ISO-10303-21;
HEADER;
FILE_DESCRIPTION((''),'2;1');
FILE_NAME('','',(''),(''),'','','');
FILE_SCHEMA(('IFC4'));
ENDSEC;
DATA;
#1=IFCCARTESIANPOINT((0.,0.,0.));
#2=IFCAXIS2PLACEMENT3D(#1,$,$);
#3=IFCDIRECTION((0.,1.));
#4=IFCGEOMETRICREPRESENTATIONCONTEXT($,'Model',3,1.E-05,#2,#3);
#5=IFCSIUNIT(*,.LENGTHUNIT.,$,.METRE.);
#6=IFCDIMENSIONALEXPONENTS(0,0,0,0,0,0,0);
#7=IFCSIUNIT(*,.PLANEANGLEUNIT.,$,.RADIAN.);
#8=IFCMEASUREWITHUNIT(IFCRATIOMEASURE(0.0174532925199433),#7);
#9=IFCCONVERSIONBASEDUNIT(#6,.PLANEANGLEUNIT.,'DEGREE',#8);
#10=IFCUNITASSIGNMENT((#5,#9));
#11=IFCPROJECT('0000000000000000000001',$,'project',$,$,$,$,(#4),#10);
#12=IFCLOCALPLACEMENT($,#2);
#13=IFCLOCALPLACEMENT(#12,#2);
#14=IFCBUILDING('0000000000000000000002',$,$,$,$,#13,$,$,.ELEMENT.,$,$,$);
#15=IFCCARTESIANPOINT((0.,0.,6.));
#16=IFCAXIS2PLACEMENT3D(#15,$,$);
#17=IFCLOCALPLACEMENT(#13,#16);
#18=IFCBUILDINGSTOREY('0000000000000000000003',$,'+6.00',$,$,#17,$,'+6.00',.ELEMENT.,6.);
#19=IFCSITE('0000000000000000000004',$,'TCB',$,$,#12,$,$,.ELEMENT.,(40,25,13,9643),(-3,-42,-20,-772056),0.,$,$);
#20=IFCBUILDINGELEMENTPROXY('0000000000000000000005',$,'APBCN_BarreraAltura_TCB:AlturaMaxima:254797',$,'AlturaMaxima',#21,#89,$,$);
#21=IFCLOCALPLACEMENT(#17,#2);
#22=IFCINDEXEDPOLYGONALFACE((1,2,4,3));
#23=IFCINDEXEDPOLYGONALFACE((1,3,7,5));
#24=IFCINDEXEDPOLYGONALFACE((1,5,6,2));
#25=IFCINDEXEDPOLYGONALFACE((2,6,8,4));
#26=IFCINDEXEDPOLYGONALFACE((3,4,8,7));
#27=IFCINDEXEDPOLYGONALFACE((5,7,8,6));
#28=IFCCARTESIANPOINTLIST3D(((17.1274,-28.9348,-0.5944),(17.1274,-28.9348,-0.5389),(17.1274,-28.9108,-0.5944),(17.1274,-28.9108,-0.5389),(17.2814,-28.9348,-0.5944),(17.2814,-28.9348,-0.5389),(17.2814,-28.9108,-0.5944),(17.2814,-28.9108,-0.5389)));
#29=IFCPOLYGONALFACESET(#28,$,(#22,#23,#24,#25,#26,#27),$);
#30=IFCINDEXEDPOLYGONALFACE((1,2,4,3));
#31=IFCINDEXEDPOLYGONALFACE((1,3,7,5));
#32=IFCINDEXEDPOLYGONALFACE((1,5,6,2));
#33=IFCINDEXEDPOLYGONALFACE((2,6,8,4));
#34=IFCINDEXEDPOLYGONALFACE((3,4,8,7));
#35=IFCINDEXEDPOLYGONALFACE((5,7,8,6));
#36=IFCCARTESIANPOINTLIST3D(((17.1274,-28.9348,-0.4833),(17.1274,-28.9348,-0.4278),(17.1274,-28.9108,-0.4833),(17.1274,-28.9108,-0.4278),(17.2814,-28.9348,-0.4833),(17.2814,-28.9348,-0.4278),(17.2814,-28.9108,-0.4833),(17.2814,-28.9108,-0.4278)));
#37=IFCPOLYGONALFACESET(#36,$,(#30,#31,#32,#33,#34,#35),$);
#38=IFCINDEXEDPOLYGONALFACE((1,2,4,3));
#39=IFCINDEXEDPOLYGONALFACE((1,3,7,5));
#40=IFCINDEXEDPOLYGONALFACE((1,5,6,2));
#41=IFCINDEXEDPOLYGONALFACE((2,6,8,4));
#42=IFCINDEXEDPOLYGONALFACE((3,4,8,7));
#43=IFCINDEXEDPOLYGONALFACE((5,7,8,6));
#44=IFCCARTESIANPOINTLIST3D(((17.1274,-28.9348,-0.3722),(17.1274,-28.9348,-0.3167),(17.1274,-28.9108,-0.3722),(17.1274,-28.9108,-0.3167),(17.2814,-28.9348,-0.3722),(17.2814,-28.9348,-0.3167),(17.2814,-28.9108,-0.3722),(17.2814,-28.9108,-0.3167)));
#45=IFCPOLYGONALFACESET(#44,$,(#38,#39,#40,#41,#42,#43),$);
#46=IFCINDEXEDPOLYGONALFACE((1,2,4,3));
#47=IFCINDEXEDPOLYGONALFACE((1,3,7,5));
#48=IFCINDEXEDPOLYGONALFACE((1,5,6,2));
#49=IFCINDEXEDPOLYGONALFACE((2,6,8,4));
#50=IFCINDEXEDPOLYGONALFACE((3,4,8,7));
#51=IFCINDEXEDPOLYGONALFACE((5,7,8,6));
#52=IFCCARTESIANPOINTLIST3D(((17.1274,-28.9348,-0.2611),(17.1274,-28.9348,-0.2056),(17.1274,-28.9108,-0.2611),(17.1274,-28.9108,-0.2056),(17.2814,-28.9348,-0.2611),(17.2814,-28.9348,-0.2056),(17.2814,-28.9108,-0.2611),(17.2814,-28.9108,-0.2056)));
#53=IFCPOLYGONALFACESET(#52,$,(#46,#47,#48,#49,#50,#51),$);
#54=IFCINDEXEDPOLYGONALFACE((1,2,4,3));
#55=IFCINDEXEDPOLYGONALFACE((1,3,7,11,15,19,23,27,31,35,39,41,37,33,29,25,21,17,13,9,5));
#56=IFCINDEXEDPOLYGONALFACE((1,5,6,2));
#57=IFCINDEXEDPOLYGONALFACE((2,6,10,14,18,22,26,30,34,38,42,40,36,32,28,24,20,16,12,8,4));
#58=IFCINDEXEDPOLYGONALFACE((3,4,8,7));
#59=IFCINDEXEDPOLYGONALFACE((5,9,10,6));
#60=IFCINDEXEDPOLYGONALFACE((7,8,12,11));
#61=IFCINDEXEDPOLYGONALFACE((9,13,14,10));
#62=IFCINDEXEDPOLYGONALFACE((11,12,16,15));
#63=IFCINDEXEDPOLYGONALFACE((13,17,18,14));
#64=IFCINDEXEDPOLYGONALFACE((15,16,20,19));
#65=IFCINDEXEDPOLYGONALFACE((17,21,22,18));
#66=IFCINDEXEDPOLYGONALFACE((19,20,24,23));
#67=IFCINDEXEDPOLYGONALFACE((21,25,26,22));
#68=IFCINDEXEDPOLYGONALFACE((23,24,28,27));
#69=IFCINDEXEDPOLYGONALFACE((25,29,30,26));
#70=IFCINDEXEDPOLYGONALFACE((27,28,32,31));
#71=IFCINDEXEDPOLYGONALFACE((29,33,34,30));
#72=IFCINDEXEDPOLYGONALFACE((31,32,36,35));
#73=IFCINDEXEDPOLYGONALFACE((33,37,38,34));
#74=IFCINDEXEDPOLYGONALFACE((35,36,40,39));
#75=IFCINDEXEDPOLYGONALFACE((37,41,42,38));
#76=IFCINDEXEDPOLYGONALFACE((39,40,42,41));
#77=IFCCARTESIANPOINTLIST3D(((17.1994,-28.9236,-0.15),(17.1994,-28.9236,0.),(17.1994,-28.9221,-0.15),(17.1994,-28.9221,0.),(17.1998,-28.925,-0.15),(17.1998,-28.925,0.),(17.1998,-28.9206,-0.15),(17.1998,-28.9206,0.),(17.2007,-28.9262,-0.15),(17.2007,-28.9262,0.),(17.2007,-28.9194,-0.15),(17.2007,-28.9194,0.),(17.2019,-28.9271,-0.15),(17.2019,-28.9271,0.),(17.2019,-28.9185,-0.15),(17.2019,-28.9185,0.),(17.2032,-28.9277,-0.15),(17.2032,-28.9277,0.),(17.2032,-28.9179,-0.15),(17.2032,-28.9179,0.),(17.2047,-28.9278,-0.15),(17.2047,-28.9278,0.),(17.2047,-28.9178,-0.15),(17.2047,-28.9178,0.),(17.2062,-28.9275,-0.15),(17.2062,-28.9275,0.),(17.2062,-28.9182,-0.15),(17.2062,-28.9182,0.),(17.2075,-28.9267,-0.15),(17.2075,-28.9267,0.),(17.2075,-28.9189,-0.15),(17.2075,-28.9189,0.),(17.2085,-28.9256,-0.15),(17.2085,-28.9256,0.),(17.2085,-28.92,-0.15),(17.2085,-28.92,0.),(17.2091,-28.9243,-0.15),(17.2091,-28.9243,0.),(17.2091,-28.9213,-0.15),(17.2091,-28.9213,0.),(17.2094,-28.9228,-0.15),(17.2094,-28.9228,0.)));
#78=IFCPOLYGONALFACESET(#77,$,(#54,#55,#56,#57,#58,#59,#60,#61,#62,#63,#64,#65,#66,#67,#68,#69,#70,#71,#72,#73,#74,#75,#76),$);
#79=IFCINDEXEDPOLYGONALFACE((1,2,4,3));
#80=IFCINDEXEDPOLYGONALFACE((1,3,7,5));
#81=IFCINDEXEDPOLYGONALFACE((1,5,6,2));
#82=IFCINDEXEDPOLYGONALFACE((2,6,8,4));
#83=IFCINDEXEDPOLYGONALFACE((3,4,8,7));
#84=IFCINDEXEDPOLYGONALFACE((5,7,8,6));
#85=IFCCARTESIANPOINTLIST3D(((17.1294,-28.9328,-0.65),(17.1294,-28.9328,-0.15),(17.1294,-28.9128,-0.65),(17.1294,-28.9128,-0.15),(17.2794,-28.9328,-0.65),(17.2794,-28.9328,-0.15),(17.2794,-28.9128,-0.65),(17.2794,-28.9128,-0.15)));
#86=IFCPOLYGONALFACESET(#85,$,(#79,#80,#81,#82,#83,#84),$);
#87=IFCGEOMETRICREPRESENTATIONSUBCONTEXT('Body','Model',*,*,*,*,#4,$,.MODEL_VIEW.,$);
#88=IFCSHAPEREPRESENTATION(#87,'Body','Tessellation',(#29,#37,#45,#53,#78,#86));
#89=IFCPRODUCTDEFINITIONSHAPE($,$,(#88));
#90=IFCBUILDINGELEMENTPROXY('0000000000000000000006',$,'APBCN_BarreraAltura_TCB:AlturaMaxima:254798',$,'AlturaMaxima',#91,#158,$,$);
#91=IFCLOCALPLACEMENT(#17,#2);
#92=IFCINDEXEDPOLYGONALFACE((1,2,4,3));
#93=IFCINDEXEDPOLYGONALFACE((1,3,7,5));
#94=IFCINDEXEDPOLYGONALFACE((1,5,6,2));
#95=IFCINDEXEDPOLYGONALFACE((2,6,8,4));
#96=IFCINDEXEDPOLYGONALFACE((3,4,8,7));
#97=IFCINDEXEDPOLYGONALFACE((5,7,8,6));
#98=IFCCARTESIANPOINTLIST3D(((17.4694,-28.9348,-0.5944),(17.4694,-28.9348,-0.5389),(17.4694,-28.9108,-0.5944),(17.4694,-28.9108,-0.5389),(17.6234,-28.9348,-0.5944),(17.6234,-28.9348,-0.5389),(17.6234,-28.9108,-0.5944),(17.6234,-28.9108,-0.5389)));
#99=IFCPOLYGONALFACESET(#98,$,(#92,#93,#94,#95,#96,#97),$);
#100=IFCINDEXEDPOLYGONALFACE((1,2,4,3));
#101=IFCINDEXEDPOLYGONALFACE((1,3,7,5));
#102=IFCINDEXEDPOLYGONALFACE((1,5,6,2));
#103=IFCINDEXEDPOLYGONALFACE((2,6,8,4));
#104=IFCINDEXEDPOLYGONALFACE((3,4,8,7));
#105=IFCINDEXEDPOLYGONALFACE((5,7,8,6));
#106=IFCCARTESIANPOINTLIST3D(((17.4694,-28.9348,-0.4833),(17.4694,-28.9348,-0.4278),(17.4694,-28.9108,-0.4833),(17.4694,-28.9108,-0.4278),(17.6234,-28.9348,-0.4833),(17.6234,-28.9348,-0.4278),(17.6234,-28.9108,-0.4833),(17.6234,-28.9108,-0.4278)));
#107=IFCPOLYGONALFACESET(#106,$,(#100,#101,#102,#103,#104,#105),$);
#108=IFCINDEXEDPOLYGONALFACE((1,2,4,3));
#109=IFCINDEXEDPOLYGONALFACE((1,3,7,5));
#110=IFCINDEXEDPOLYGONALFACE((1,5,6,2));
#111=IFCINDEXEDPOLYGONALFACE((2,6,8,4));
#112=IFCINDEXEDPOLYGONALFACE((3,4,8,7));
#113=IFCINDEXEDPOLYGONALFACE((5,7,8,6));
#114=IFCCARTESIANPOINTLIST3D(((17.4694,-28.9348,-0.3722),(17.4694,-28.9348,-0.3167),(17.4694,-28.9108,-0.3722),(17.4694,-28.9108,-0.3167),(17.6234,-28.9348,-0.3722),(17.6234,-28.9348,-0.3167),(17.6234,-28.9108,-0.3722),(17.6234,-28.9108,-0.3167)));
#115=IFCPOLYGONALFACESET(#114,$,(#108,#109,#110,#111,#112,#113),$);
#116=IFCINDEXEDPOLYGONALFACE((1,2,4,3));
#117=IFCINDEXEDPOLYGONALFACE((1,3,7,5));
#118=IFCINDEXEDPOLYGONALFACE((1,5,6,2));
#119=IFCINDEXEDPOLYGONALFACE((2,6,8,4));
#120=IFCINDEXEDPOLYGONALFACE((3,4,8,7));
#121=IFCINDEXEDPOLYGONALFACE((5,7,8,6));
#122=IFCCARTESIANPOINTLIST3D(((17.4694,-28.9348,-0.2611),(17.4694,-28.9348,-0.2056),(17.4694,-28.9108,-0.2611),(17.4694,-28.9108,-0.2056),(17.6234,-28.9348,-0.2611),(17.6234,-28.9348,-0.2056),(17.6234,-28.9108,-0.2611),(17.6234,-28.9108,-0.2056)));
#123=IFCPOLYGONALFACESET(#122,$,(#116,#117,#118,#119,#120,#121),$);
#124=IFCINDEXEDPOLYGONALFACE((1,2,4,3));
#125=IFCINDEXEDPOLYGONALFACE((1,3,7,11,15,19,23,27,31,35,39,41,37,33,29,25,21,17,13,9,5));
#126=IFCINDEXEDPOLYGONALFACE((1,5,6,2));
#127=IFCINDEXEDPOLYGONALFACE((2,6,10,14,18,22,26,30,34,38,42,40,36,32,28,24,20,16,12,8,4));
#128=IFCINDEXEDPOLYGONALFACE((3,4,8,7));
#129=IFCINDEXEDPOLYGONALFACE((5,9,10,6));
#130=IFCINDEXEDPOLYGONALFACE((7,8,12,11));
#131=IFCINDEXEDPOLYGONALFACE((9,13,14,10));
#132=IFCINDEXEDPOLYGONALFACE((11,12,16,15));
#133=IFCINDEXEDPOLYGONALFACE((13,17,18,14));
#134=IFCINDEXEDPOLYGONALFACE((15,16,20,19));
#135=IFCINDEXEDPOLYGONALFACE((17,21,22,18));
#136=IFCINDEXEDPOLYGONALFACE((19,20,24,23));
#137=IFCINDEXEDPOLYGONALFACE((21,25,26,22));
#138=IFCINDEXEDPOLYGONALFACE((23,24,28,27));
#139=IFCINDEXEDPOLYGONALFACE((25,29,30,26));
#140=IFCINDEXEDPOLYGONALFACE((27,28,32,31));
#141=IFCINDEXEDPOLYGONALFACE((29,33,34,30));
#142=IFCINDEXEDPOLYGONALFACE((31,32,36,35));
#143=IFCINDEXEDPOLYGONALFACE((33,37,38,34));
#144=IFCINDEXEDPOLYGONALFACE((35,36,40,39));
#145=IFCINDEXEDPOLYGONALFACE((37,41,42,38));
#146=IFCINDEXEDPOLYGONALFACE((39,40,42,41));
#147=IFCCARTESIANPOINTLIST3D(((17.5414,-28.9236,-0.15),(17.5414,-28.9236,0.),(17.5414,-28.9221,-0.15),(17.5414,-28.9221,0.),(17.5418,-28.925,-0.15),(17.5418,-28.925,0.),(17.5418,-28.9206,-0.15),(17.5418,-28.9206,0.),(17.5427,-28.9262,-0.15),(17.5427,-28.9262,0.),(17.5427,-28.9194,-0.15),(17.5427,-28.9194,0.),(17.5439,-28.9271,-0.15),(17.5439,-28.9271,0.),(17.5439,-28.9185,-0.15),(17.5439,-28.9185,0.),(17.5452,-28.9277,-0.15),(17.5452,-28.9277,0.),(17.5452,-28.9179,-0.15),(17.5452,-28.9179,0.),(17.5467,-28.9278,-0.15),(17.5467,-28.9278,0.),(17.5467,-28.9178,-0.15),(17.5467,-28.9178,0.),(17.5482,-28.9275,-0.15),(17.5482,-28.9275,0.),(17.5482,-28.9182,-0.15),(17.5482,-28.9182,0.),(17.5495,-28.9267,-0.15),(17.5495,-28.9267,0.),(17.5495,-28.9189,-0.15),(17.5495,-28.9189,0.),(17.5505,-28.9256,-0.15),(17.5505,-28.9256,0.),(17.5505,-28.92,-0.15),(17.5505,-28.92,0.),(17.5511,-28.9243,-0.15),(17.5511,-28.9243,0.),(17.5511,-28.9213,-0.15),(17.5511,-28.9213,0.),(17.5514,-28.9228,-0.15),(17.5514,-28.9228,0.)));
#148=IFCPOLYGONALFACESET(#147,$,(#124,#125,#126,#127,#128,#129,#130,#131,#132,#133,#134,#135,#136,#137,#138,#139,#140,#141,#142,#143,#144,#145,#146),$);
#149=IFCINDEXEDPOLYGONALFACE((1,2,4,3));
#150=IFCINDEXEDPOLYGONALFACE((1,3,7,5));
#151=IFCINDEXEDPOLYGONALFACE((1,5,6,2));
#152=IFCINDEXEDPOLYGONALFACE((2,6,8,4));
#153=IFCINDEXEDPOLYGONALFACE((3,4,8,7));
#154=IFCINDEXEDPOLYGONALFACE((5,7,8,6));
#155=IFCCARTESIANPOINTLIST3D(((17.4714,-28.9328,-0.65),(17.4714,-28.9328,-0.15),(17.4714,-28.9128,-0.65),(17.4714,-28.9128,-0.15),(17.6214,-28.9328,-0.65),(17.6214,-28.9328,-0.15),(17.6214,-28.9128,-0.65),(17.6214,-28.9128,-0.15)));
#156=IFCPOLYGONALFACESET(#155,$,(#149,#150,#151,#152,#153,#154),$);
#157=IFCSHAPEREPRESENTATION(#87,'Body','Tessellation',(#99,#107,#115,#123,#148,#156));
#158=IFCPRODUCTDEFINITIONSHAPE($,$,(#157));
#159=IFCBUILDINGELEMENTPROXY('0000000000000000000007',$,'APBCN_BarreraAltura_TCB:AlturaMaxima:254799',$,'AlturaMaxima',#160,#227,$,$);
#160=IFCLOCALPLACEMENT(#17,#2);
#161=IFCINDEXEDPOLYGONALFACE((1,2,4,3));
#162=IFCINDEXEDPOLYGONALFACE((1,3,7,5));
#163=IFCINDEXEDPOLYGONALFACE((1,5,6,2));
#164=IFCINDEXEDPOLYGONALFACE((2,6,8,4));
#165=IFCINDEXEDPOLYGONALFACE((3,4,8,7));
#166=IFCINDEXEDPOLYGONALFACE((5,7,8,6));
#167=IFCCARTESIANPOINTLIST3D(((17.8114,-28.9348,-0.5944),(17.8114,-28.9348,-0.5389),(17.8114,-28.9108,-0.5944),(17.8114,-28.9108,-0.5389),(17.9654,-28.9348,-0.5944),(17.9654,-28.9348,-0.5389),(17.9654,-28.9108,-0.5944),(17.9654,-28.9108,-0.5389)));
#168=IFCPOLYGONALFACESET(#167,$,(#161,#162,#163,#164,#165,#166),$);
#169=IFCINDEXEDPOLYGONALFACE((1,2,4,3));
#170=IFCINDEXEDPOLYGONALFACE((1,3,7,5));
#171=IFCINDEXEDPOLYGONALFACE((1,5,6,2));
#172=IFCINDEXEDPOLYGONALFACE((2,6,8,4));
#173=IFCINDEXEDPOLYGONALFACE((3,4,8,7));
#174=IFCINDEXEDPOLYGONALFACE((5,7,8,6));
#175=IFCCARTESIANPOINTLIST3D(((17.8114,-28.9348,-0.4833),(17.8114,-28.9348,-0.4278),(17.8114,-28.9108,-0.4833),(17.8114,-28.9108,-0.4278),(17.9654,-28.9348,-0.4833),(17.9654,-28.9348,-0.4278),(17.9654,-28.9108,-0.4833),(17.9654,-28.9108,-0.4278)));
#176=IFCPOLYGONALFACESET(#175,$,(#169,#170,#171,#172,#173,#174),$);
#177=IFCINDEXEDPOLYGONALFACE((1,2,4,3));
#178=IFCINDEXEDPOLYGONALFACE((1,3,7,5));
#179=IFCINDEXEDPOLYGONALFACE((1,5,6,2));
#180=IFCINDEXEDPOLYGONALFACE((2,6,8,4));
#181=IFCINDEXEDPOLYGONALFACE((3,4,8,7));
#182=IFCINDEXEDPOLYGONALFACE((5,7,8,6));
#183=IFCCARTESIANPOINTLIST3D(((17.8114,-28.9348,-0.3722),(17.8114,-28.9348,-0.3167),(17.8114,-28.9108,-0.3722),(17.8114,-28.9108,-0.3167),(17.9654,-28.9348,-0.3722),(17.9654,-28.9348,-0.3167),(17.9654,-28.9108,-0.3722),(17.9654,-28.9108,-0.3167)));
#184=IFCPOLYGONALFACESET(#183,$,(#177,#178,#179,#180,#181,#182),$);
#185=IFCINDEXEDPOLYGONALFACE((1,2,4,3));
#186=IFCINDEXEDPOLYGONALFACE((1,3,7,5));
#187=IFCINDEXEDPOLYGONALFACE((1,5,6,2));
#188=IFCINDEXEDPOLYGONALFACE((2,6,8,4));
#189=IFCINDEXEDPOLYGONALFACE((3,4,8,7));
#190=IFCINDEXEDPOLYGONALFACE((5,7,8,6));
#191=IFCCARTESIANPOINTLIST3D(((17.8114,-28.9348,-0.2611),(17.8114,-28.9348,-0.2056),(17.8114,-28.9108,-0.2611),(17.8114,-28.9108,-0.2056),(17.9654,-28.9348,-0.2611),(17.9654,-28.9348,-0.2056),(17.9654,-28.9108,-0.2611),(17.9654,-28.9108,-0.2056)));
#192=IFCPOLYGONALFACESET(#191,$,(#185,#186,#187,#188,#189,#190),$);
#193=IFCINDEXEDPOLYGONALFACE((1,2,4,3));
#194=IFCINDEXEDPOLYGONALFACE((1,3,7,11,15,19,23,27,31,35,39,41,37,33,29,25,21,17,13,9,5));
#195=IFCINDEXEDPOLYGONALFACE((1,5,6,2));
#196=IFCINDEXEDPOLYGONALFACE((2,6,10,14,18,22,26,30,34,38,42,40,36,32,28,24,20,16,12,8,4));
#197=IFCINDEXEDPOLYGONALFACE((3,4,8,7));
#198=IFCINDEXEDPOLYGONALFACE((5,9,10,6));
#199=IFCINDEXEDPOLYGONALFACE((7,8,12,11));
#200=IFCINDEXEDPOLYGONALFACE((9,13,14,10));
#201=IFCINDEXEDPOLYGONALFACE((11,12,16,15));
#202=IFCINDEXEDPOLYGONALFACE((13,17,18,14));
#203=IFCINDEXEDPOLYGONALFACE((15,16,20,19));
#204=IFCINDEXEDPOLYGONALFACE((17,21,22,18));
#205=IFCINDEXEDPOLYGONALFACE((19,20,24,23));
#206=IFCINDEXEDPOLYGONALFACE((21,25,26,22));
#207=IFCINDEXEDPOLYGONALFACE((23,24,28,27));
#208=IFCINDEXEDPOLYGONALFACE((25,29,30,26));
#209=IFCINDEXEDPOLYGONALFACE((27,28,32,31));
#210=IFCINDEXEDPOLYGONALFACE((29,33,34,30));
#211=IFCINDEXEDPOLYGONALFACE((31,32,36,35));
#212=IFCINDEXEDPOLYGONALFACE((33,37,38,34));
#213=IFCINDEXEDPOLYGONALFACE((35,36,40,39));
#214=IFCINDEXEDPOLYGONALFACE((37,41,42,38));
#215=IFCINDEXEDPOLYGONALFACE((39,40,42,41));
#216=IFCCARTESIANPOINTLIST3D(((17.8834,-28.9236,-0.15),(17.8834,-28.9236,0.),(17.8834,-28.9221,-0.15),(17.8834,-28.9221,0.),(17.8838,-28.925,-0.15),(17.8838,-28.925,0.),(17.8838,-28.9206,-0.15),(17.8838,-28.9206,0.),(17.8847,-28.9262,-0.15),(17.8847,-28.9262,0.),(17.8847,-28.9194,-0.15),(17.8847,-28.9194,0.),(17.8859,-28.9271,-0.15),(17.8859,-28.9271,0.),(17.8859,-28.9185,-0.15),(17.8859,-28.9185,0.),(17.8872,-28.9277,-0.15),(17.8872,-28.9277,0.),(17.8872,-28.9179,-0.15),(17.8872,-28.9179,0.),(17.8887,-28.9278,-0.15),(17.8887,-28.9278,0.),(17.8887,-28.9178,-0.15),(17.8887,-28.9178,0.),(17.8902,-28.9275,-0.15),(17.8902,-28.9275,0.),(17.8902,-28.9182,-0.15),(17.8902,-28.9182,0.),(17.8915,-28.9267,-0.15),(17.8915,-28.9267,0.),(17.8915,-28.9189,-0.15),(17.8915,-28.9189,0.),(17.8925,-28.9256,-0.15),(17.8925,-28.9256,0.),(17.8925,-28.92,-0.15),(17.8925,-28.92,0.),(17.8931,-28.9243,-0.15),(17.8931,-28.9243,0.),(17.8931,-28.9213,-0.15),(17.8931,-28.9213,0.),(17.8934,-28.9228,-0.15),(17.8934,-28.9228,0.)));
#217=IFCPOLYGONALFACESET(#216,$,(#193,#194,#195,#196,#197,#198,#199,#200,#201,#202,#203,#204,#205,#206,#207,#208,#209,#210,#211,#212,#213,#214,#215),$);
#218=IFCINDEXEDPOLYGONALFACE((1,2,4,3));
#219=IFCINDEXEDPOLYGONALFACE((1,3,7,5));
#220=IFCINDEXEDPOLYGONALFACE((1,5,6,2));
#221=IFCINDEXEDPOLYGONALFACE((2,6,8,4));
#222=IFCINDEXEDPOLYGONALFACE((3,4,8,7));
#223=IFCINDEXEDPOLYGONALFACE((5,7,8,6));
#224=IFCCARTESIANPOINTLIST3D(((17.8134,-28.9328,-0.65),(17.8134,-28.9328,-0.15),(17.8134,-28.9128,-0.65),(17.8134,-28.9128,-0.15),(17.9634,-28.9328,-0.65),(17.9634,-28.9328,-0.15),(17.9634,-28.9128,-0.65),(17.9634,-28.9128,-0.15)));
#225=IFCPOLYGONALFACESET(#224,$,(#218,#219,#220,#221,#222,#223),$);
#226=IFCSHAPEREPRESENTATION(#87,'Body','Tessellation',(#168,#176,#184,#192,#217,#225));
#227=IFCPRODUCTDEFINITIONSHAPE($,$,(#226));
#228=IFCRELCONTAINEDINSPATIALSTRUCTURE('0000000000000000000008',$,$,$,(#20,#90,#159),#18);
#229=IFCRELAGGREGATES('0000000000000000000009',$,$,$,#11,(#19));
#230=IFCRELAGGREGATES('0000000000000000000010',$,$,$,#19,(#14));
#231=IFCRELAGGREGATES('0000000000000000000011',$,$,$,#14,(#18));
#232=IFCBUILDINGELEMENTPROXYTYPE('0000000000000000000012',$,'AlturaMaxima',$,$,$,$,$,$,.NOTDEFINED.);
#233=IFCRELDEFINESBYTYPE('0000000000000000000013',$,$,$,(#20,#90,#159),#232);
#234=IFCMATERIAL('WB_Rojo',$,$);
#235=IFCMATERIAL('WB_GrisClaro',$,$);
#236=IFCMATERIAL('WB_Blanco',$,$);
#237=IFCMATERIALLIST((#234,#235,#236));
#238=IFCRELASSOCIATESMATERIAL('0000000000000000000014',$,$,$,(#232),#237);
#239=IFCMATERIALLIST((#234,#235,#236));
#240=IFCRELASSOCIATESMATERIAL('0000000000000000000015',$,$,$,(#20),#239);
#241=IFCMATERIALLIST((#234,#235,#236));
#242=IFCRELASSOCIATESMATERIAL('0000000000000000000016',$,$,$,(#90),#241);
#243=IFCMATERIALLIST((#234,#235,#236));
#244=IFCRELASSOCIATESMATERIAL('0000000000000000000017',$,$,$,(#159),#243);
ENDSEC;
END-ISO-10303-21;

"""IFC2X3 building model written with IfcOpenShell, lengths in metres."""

from ifc_helpers import new_model, entity, si_unit, converted_unit, direction, frame, frame_2d, origin, origin_2d_with_axis, place, context, subcontext, project, spatial, rectangle, circle, extrude, source, transform, mapped, material, material_list, type_object, type_shapes, element, save


model = new_model("IFC2X3")

# Units and contexts
model_context = context("Model", 3, precision=1e-05, world=origin(), true_north=direction((0.0, 1.0)))
body_context = subcontext(model_context, "Body", "Model", "MODEL_VIEW")
ifc_project = project(units=[si_unit("LENGTHUNIT", "METRE"), converted_unit("PLANEANGLEUNIT", "DEGREE", entity("IfcRatioMeasure", 0.0174532925199433), si_unit("PLANEANGLEUNIT", "RADIAN"), dimensions=[0, 0, 0, 0, 0, 0, 0])], contexts=[model_context])

# Site, building, storey
site_placement = place(None, origin())
site = spatial("IfcSite", under=ifc_project, at=site_placement, Name="TCB", CompositionType="ELEMENT", RefLatitude=(40, 25, 13, 9643), RefLongitude=(-3, -42, -20, -772056), RefElevation=0.0)
building_placement = place(site_placement, origin())
building = spatial("IfcBuilding", under=site, at=building_placement, CompositionType="ELEMENT")
storey_placement = place(building_placement, frame((0.0, 0.0, 6.0)))
storey = spatial("IfcBuildingStorey", under=building, at=storey_placement, Name="+6.00", LongName="+6.00", CompositionType="ELEMENT", Elevation=6.0)

# Building element proxies
ifc_material_1 = material(Name="WB_Rojo")
ifc_material_2 = material(Name="WB_GrisClaro")
ifc_material_3 = material(Name="WB_Blanco")
ifc_material_list_1 = material_list([ifc_material_1, ifc_material_2, ifc_material_3])
building_element_proxy_type = type_object("IfcBuildingElementProxyType", Name="AlturaMaxima", PredefinedType="NOTDEFINED", material=ifc_material_list_1)
shared_shape = source(origin(), body_context, "Body", "SweptSolid", [
    extrude(rectangle(XDim=0.154, YDim=0.024, at=frame_2d((0.0, 0.0), x_axis=(1.0, 0.0))), frame((0.0, 0.0, -0.5944), z_axis=(0.0, 0.0, 1.0), x_axis=(-1.0, 0.0, 0.0)), (0.0, 0.0, 1.0), 0.0556),
    extrude(rectangle(XDim=0.154, YDim=0.024, at=frame_2d((0.0, 0.0), x_axis=(1.0, 0.0))), frame((0.0, 0.0, -0.4833), z_axis=(0.0, 0.0, 1.0), x_axis=(-1.0, 0.0, 0.0)), (0.0, 0.0, 1.0), 0.0556),
    extrude(rectangle(XDim=0.154, YDim=0.024, at=frame_2d((0.0, 0.0), x_axis=(1.0, 0.0))), frame((0.0, 0.0, -0.3722), z_axis=(0.0, 0.0, 1.0), x_axis=(-1.0, 0.0, 0.0)), (0.0, 0.0, 1.0), 0.0556),
    extrude(rectangle(XDim=0.154, YDim=0.024, at=frame_2d((0.0, 0.0), x_axis=(1.0, 0.0))), frame((0.0, 0.0, -0.2611), z_axis=(0.0, 0.0, 1.0), x_axis=(-1.0, 0.0, 0.0)), (0.0, 0.0, 1.0), 0.0556),
    extrude(circle(Radius=0.005, at=frame_2d((0.0, 0.0), x_axis=(1.0, 0.0))), frame((0.0, 0.0, -0.15)), (0.0, 0.0, 1.0), 0.15),
    extrude(rectangle(XDim=0.02, YDim=0.15, at=origin_2d_with_axis()), frame((0.0, 0.0, -0.65), z_axis=(0.0, 0.0, 1.0), x_axis=(0.0, 1.0, 0.0)), (0.0, 0.0, 1.0), 0.5),
])
type_shapes(building_element_proxy_type, [shared_shape])
ifc_material_list_2 = material_list([ifc_material_1, ifc_material_2, ifc_material_3])
proxy_1_placement = place(storey_placement, frame((17.2044, -28.9228, 0.0)))
element("IfcBuildingElementProxy", 1, at=proxy_1_placement, inside=storey, type_object=building_element_proxy_type, material=ifc_material_list_2, Name="APBCN_BarreraAltura_TCB:AlturaMaxima:254797", ObjectType="AlturaMaxima", context=body_context, shape_type="MappedRepresentation", body=[
    mapped(shared_shape, transform((0.0, 0.0, 0.0), scale=1.0)),
])
ifc_material_list_3 = material_list([ifc_material_1, ifc_material_2, ifc_material_3])
proxy_2_placement = place(storey_placement, frame((17.5464, -28.9228, 0.0)))
element("IfcBuildingElementProxy", 2, at=proxy_2_placement, inside=storey, type_object=building_element_proxy_type, material=ifc_material_list_3, Name="APBCN_BarreraAltura_TCB:AlturaMaxima:254798", ObjectType="AlturaMaxima", context=body_context, shape_type="MappedRepresentation", body=[
    mapped(shared_shape, transform((0.0, 0.0, 0.0), scale=1.0)),
])
ifc_material_list_4 = material_list([ifc_material_1, ifc_material_2, ifc_material_3])
proxy_3_placement = place(storey_placement, frame((17.8884, -28.9228, 0.0)))
element("IfcBuildingElementProxy", 3, at=proxy_3_placement, inside=storey, type_object=building_element_proxy_type, material=ifc_material_list_4, Name="APBCN_BarreraAltura_TCB:AlturaMaxima:254799", ObjectType="AlturaMaxima", context=body_context, shape_type="MappedRepresentation", body=[
    mapped(shared_shape, transform((0.0, 0.0, 0.0), scale=1.0)),
])

save(model, "model.ifc")
